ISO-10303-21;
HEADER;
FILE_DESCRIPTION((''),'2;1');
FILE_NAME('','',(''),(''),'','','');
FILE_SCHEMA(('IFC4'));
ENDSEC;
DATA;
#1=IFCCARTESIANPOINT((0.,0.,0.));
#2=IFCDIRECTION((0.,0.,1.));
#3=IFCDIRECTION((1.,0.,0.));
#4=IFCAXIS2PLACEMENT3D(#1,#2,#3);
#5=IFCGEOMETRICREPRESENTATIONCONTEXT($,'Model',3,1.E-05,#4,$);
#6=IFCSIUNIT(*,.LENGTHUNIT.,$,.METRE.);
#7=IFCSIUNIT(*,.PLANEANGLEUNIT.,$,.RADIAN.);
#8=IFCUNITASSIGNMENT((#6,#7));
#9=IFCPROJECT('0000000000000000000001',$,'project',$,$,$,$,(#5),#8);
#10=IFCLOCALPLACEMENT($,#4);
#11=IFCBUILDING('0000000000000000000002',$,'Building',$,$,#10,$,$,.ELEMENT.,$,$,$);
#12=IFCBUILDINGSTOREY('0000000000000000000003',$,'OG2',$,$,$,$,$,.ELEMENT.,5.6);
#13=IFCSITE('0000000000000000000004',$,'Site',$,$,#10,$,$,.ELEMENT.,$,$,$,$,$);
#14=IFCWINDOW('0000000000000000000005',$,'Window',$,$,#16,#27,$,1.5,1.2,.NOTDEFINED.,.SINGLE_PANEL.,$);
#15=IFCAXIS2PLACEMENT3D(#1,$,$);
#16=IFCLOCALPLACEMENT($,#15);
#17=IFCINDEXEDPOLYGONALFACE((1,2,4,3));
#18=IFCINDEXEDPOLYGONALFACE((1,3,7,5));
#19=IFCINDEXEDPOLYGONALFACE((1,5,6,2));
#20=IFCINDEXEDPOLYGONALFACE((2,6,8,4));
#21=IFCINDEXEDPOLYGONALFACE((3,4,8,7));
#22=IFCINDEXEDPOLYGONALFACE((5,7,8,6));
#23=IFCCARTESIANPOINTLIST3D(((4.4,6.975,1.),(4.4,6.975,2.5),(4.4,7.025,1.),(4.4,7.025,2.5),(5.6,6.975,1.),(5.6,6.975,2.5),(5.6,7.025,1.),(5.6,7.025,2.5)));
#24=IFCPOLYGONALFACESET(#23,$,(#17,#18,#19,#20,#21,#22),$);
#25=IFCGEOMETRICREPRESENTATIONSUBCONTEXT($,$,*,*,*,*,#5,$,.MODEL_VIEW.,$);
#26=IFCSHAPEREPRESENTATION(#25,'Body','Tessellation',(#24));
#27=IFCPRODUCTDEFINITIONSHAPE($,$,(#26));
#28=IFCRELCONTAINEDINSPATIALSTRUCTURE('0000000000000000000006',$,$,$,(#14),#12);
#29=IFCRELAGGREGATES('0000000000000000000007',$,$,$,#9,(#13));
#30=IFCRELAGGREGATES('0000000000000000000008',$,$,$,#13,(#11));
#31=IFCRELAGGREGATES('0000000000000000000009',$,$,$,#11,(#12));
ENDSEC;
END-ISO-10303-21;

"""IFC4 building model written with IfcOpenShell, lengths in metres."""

from ifc_helpers import new_model, si_unit, frame, origin, origin_with_axes, origin_2d, place, context, subcontext, project, spatial, rectangle, extrude, element, save


model = new_model("IFC4")

# Units and contexts
model_context = context("Model", 3, precision=1e-05, world=origin_with_axes())
sub_context = subcontext(model_context, None, None, "MODEL_VIEW")
ifc_project = project(units=[si_unit("LENGTHUNIT", "METRE"), si_unit("PLANEANGLEUNIT", "RADIAN")], contexts=[model_context])

# Site, building, storey
placement_1 = place(None, origin_with_axes())
site = spatial("IfcSite", under=ifc_project, at=placement_1, Name="Site", CompositionType="ELEMENT")
building = spatial("IfcBuilding", under=site, at=placement_1, Name="Building", CompositionType="ELEMENT")
storey = spatial("IfcBuildingStorey", under=building, Name="OG2", CompositionType="ELEMENT", Elevation=5.6)

# Window
placement_2 = place(None, origin_with_axes())
window_placement = place(placement_2, frame((5.0, 7.0, 1.0)))
element("IfcWindow", 1, at=window_placement, inside=storey, Name="Window", OverallHeight=1.5, OverallWidth=1.2, PartitioningType="SINGLE_PANEL", PredefinedType="NOTDEFINED", context=sub_context, shape_type="SweptSolid", body=[
    extrude(rectangle(XDim=1.2, YDim=0.05, at=origin_2d()), origin(), (0.0, 0.0, 1.0), 1.5),
])

save(model, "model.ifc")
